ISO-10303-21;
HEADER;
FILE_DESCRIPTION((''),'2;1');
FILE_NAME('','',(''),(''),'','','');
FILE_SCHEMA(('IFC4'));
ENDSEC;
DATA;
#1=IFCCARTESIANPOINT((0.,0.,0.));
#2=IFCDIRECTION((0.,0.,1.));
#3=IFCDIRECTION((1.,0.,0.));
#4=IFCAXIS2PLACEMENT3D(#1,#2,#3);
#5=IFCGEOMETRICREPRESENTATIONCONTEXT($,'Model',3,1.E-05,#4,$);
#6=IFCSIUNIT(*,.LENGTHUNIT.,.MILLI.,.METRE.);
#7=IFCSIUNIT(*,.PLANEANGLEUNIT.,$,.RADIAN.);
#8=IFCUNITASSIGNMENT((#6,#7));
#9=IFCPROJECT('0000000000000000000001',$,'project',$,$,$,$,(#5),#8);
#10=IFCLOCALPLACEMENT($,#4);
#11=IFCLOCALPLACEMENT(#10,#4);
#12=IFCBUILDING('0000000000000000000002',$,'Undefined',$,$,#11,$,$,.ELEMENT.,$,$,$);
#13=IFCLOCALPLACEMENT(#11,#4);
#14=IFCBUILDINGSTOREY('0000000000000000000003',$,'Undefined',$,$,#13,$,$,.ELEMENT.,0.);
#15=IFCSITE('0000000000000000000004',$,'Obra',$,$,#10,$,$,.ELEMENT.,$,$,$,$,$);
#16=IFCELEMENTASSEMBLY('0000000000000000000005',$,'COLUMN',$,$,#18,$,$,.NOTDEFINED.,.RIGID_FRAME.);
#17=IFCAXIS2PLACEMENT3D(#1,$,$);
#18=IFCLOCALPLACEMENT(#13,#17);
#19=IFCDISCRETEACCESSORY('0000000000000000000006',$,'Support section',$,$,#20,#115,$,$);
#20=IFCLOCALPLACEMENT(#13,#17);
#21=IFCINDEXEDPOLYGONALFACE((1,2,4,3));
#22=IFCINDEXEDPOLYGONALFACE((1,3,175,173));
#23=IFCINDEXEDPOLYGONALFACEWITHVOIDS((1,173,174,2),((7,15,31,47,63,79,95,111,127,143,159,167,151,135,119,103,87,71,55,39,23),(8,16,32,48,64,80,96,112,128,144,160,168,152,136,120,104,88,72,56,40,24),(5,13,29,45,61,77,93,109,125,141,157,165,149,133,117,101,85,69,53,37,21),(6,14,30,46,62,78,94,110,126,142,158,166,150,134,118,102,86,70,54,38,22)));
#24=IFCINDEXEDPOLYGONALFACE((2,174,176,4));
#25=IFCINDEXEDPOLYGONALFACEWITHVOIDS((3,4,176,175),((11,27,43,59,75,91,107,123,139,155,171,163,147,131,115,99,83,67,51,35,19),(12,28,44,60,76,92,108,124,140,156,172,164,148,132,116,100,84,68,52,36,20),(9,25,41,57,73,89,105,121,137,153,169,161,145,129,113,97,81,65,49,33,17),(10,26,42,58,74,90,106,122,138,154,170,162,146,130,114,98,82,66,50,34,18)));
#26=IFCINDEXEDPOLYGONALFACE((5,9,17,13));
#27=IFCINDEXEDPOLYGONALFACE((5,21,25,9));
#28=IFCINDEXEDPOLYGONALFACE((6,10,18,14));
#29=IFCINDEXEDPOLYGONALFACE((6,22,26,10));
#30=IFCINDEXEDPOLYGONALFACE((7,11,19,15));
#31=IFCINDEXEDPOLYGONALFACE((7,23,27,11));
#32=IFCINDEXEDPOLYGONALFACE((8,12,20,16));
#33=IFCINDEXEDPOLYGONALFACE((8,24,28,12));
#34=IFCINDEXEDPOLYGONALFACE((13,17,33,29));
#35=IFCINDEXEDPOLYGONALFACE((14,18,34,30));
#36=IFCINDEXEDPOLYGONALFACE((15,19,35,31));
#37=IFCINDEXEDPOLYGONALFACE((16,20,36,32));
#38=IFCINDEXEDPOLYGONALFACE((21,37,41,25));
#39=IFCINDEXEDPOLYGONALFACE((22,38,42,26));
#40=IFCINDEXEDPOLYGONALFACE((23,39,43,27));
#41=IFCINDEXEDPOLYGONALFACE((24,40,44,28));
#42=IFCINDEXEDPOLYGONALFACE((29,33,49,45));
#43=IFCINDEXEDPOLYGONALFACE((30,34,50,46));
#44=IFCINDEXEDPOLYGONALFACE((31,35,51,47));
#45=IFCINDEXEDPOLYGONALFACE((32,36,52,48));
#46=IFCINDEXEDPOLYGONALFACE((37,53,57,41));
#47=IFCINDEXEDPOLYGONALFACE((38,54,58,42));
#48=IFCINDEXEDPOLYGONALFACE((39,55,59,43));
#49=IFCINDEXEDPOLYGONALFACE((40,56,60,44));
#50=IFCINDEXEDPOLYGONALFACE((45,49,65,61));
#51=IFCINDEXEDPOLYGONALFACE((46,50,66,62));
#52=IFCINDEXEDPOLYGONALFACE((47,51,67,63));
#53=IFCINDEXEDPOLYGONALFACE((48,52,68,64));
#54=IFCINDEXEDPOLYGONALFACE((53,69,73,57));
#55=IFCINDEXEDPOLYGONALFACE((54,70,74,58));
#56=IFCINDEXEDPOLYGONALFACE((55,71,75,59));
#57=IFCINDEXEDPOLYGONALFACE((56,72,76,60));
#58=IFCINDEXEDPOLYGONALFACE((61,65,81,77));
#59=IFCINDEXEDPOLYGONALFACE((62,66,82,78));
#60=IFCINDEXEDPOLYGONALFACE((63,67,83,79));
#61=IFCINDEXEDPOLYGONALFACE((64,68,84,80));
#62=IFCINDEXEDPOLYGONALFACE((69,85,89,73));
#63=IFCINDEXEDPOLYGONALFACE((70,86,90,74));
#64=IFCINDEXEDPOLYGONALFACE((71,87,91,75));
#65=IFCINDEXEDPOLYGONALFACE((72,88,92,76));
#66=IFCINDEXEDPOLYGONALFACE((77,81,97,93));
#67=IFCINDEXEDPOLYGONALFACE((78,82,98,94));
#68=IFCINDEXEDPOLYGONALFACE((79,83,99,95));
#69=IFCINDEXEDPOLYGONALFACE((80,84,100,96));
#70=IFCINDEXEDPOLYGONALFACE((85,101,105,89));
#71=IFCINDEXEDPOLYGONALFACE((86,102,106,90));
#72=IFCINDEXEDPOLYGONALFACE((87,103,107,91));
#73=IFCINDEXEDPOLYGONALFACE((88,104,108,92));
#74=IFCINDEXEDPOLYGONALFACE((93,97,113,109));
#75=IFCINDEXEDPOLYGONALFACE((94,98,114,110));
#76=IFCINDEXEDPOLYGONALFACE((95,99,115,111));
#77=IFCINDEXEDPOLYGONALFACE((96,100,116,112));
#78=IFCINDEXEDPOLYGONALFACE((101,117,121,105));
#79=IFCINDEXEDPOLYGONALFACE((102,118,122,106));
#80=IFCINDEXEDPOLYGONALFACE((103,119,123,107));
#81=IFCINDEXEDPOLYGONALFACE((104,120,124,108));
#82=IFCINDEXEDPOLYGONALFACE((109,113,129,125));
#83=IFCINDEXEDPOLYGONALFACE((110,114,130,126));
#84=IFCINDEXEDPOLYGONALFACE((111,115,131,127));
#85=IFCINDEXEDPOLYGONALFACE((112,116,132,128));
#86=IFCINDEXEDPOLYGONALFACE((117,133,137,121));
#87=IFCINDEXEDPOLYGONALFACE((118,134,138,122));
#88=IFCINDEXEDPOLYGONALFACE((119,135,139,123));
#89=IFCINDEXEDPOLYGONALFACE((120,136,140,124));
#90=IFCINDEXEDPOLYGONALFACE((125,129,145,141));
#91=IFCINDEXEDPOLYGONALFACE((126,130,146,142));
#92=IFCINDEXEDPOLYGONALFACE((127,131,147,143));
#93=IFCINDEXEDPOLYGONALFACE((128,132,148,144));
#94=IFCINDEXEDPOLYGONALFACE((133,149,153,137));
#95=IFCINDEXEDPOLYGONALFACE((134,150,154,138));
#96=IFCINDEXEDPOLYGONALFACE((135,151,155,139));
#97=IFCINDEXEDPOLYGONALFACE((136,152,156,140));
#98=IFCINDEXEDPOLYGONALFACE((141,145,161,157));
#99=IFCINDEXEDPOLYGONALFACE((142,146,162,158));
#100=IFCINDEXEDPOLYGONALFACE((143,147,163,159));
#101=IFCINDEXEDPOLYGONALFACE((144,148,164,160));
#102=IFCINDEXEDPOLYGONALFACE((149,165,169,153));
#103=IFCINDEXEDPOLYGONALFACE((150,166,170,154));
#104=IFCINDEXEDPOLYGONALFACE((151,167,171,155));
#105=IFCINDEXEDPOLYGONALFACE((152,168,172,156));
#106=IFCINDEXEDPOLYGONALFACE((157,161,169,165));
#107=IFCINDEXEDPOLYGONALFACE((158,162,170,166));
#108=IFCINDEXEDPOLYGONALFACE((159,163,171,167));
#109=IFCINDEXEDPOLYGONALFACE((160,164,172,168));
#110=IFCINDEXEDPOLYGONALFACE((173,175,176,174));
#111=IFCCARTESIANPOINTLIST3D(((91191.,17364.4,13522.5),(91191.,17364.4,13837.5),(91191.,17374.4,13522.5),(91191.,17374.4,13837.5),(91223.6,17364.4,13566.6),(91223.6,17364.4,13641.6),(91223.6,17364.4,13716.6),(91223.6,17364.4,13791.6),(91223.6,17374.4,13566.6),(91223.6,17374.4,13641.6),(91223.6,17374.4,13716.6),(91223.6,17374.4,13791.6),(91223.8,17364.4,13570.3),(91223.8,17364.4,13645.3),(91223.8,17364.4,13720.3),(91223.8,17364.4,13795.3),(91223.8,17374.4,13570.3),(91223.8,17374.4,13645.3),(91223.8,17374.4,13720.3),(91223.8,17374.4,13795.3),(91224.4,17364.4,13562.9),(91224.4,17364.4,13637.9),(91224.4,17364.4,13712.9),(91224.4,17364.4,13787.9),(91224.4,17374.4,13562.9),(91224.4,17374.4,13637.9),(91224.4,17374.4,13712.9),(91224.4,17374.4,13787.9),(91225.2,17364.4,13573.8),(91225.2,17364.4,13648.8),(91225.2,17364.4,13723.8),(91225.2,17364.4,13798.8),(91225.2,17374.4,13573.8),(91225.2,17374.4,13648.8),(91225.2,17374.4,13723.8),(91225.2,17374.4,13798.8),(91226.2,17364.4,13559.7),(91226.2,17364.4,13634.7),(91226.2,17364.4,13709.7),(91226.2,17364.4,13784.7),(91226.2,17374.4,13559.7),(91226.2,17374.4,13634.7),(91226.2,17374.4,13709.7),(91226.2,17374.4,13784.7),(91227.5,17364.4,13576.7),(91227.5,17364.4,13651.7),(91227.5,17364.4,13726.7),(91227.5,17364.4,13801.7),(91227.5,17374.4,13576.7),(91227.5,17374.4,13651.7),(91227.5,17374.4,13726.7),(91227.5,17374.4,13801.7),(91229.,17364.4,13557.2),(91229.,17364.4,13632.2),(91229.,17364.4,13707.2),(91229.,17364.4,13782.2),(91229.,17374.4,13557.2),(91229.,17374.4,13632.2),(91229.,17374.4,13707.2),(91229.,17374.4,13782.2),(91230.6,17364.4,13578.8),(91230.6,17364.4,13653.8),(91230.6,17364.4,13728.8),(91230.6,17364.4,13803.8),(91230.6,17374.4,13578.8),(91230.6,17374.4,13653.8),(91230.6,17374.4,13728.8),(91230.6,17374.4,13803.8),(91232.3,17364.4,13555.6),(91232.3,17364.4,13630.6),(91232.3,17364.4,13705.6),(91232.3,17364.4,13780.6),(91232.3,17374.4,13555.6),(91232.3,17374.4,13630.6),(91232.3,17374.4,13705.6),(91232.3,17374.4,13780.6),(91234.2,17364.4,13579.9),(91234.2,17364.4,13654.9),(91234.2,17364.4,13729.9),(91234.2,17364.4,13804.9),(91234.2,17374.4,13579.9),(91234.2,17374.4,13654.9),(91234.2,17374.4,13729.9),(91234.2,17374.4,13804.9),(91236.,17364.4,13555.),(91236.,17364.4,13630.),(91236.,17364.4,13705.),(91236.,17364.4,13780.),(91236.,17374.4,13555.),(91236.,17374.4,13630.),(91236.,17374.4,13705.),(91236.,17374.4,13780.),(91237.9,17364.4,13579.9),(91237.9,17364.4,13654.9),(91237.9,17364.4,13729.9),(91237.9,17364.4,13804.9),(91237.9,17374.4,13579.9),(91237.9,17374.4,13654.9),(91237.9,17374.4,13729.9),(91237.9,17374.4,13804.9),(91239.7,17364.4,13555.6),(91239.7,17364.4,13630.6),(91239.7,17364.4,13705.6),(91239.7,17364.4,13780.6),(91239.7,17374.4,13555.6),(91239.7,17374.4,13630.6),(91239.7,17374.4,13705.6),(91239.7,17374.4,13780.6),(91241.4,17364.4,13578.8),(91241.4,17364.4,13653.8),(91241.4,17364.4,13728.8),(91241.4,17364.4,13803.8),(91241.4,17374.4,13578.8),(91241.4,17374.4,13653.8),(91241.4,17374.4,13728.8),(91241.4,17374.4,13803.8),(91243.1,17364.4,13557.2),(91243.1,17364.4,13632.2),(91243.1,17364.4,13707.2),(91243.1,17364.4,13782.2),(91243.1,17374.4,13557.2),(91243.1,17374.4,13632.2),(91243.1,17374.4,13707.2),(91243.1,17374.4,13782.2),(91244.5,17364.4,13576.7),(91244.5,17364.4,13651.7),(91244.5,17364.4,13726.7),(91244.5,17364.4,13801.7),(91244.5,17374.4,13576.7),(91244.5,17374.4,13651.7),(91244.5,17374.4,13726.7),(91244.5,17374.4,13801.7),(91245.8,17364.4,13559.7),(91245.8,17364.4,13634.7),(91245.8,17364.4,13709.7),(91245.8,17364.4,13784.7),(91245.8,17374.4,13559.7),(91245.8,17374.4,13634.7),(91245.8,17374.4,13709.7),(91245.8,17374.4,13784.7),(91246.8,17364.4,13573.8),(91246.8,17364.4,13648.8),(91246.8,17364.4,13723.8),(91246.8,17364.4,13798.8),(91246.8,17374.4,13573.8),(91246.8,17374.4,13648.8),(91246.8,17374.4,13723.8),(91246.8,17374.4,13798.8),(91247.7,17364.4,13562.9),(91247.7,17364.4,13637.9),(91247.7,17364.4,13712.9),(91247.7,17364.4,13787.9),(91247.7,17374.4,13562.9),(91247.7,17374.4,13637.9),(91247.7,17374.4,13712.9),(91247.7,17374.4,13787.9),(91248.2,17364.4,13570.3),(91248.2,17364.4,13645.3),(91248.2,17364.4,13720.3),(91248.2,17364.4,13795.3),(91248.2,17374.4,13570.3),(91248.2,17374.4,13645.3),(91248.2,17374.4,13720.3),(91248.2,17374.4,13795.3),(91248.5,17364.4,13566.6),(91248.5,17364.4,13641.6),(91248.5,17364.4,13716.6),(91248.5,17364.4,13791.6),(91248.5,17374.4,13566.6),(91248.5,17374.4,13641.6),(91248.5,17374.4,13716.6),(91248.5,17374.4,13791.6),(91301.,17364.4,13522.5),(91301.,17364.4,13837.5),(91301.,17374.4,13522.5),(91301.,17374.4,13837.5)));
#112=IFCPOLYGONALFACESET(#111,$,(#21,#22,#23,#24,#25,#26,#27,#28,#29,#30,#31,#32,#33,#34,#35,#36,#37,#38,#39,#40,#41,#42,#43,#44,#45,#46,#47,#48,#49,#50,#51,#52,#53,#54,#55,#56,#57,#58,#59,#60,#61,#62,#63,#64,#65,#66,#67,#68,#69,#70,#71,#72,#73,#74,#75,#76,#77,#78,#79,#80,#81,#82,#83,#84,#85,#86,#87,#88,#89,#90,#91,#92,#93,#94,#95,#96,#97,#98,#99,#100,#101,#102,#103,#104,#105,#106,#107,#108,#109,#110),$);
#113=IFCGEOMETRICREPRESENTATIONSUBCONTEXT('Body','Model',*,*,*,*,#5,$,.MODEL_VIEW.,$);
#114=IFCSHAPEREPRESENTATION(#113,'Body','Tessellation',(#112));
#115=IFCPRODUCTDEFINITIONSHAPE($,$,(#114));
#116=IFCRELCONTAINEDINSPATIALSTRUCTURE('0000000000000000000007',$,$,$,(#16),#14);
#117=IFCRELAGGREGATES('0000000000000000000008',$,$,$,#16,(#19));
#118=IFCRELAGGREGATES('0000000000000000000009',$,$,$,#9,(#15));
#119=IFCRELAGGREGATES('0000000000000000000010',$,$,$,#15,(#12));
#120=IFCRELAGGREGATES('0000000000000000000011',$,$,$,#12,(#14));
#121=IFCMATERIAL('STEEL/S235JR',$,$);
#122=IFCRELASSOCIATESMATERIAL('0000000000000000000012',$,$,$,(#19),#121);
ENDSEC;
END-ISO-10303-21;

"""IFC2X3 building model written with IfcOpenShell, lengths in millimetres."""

from ifc_helpers import new_model, si_unit, frame, origin_with_axes, origin_2d_with_axis, place, context, subcontext, project, spatial, rectangle, circle, extrude, source, transform, mapped, material, element, aggregate, save


model = new_model("IFC2X3")

# Units and contexts
model_context = context("Model", 3, precision=1e-05, world=origin_with_axes())
body_context = subcontext(model_context, "Body", "Model", "MODEL_VIEW")
ifc_project = project(units=[si_unit("LENGTHUNIT", "METRE", prefix="MILLI"), si_unit("PLANEANGLEUNIT", "RADIAN")], contexts=[model_context])

# Site, building, storey
site_placement = place(None, origin_with_axes())
site = spatial("IfcSite", under=ifc_project, at=site_placement, Name="Obra", CompositionType="ELEMENT")
building_placement = place(site_placement, origin_with_axes())
building = spatial("IfcBuilding", under=site, at=building_placement, Name="Undefined", CompositionType="ELEMENT")
storey_placement = place(building_placement, origin_with_axes())
storey = spatial("IfcBuildingStorey", under=building, at=storey_placement, Name="Undefined", CompositionType="ELEMENT", Elevation=0.0)

# Element assembly
assembly_1_placement = place(storey_placement, origin_with_axes())
assembly_1 = element("IfcElementAssembly", 1, at=assembly_1_placement, inside=storey, Name="COLUMN", AssemblyPlace="NOTDEFINED", PredefinedType="RIGID_FRAME")
ifc_material_1 = material(Name="STEEL/S235JR")

# Discrete accessory, opening
shared_shape_1 = source(origin_with_axes(), body_context, "Body", "SweptSolid", [
    extrude(circle(Radius=12.5, at=origin_2d_with_axis()), frame((0.0, 5.7, 0.0), z_axis=(0.0, 1.0, 0.0), x_axis=(1.0, 0.0, 0.0)), (0.0, 0.0, 1.0), 10.2),
])
discrete_accessory_1_placement = place(assembly_1_placement, frame((91246.0, 17369.4, 13522.5), z_axis=(0.0, 0.0, 1.0), x_axis=(1.0, 0.0, 0.0)))
discrete_accessory_1 = element("IfcDiscreteAccessory", 2, at=discrete_accessory_1_placement, material=ifc_material_1, Name="Support section", context=body_context, shape_type="SweptSolid", body=[
    extrude(rectangle(XDim=10.0, YDim=110.0, at=origin_2d_with_axis()), frame((0.0, 0.0, 315.0), z_axis=(0.0, 0.0, -1.0), x_axis=(0.0, 1.0, 0.0)), (0.0, 0.0, 1.0), 315.0),
])
opening_1_placement = place(assembly_1_placement, frame((91281.0, 17380.1, 13900.0), z_axis=(-1.0, 0.0, 0.0), x_axis=(0.0, 0.0, -1.0)))
element("IfcOpeningElement", 3, at=opening_1_placement, cuts=discrete_accessory_1, ObjectType="Opening", context=body_context, shape_type="MappedRepresentation", body=[
    mapped(shared_shape_1, transform((107.5, 0.0, 45.0))),
    mapped(shared_shape_1, transform((182.5, 0.0, 45.0))),
    mapped(shared_shape_1, transform((257.5, 0.0, 45.0))),
    mapped(shared_shape_1, transform((332.5, 0.0, 45.0))),
])

aggregate(assembly_1, [discrete_accessory_1])

save(model, "model.ifc")
